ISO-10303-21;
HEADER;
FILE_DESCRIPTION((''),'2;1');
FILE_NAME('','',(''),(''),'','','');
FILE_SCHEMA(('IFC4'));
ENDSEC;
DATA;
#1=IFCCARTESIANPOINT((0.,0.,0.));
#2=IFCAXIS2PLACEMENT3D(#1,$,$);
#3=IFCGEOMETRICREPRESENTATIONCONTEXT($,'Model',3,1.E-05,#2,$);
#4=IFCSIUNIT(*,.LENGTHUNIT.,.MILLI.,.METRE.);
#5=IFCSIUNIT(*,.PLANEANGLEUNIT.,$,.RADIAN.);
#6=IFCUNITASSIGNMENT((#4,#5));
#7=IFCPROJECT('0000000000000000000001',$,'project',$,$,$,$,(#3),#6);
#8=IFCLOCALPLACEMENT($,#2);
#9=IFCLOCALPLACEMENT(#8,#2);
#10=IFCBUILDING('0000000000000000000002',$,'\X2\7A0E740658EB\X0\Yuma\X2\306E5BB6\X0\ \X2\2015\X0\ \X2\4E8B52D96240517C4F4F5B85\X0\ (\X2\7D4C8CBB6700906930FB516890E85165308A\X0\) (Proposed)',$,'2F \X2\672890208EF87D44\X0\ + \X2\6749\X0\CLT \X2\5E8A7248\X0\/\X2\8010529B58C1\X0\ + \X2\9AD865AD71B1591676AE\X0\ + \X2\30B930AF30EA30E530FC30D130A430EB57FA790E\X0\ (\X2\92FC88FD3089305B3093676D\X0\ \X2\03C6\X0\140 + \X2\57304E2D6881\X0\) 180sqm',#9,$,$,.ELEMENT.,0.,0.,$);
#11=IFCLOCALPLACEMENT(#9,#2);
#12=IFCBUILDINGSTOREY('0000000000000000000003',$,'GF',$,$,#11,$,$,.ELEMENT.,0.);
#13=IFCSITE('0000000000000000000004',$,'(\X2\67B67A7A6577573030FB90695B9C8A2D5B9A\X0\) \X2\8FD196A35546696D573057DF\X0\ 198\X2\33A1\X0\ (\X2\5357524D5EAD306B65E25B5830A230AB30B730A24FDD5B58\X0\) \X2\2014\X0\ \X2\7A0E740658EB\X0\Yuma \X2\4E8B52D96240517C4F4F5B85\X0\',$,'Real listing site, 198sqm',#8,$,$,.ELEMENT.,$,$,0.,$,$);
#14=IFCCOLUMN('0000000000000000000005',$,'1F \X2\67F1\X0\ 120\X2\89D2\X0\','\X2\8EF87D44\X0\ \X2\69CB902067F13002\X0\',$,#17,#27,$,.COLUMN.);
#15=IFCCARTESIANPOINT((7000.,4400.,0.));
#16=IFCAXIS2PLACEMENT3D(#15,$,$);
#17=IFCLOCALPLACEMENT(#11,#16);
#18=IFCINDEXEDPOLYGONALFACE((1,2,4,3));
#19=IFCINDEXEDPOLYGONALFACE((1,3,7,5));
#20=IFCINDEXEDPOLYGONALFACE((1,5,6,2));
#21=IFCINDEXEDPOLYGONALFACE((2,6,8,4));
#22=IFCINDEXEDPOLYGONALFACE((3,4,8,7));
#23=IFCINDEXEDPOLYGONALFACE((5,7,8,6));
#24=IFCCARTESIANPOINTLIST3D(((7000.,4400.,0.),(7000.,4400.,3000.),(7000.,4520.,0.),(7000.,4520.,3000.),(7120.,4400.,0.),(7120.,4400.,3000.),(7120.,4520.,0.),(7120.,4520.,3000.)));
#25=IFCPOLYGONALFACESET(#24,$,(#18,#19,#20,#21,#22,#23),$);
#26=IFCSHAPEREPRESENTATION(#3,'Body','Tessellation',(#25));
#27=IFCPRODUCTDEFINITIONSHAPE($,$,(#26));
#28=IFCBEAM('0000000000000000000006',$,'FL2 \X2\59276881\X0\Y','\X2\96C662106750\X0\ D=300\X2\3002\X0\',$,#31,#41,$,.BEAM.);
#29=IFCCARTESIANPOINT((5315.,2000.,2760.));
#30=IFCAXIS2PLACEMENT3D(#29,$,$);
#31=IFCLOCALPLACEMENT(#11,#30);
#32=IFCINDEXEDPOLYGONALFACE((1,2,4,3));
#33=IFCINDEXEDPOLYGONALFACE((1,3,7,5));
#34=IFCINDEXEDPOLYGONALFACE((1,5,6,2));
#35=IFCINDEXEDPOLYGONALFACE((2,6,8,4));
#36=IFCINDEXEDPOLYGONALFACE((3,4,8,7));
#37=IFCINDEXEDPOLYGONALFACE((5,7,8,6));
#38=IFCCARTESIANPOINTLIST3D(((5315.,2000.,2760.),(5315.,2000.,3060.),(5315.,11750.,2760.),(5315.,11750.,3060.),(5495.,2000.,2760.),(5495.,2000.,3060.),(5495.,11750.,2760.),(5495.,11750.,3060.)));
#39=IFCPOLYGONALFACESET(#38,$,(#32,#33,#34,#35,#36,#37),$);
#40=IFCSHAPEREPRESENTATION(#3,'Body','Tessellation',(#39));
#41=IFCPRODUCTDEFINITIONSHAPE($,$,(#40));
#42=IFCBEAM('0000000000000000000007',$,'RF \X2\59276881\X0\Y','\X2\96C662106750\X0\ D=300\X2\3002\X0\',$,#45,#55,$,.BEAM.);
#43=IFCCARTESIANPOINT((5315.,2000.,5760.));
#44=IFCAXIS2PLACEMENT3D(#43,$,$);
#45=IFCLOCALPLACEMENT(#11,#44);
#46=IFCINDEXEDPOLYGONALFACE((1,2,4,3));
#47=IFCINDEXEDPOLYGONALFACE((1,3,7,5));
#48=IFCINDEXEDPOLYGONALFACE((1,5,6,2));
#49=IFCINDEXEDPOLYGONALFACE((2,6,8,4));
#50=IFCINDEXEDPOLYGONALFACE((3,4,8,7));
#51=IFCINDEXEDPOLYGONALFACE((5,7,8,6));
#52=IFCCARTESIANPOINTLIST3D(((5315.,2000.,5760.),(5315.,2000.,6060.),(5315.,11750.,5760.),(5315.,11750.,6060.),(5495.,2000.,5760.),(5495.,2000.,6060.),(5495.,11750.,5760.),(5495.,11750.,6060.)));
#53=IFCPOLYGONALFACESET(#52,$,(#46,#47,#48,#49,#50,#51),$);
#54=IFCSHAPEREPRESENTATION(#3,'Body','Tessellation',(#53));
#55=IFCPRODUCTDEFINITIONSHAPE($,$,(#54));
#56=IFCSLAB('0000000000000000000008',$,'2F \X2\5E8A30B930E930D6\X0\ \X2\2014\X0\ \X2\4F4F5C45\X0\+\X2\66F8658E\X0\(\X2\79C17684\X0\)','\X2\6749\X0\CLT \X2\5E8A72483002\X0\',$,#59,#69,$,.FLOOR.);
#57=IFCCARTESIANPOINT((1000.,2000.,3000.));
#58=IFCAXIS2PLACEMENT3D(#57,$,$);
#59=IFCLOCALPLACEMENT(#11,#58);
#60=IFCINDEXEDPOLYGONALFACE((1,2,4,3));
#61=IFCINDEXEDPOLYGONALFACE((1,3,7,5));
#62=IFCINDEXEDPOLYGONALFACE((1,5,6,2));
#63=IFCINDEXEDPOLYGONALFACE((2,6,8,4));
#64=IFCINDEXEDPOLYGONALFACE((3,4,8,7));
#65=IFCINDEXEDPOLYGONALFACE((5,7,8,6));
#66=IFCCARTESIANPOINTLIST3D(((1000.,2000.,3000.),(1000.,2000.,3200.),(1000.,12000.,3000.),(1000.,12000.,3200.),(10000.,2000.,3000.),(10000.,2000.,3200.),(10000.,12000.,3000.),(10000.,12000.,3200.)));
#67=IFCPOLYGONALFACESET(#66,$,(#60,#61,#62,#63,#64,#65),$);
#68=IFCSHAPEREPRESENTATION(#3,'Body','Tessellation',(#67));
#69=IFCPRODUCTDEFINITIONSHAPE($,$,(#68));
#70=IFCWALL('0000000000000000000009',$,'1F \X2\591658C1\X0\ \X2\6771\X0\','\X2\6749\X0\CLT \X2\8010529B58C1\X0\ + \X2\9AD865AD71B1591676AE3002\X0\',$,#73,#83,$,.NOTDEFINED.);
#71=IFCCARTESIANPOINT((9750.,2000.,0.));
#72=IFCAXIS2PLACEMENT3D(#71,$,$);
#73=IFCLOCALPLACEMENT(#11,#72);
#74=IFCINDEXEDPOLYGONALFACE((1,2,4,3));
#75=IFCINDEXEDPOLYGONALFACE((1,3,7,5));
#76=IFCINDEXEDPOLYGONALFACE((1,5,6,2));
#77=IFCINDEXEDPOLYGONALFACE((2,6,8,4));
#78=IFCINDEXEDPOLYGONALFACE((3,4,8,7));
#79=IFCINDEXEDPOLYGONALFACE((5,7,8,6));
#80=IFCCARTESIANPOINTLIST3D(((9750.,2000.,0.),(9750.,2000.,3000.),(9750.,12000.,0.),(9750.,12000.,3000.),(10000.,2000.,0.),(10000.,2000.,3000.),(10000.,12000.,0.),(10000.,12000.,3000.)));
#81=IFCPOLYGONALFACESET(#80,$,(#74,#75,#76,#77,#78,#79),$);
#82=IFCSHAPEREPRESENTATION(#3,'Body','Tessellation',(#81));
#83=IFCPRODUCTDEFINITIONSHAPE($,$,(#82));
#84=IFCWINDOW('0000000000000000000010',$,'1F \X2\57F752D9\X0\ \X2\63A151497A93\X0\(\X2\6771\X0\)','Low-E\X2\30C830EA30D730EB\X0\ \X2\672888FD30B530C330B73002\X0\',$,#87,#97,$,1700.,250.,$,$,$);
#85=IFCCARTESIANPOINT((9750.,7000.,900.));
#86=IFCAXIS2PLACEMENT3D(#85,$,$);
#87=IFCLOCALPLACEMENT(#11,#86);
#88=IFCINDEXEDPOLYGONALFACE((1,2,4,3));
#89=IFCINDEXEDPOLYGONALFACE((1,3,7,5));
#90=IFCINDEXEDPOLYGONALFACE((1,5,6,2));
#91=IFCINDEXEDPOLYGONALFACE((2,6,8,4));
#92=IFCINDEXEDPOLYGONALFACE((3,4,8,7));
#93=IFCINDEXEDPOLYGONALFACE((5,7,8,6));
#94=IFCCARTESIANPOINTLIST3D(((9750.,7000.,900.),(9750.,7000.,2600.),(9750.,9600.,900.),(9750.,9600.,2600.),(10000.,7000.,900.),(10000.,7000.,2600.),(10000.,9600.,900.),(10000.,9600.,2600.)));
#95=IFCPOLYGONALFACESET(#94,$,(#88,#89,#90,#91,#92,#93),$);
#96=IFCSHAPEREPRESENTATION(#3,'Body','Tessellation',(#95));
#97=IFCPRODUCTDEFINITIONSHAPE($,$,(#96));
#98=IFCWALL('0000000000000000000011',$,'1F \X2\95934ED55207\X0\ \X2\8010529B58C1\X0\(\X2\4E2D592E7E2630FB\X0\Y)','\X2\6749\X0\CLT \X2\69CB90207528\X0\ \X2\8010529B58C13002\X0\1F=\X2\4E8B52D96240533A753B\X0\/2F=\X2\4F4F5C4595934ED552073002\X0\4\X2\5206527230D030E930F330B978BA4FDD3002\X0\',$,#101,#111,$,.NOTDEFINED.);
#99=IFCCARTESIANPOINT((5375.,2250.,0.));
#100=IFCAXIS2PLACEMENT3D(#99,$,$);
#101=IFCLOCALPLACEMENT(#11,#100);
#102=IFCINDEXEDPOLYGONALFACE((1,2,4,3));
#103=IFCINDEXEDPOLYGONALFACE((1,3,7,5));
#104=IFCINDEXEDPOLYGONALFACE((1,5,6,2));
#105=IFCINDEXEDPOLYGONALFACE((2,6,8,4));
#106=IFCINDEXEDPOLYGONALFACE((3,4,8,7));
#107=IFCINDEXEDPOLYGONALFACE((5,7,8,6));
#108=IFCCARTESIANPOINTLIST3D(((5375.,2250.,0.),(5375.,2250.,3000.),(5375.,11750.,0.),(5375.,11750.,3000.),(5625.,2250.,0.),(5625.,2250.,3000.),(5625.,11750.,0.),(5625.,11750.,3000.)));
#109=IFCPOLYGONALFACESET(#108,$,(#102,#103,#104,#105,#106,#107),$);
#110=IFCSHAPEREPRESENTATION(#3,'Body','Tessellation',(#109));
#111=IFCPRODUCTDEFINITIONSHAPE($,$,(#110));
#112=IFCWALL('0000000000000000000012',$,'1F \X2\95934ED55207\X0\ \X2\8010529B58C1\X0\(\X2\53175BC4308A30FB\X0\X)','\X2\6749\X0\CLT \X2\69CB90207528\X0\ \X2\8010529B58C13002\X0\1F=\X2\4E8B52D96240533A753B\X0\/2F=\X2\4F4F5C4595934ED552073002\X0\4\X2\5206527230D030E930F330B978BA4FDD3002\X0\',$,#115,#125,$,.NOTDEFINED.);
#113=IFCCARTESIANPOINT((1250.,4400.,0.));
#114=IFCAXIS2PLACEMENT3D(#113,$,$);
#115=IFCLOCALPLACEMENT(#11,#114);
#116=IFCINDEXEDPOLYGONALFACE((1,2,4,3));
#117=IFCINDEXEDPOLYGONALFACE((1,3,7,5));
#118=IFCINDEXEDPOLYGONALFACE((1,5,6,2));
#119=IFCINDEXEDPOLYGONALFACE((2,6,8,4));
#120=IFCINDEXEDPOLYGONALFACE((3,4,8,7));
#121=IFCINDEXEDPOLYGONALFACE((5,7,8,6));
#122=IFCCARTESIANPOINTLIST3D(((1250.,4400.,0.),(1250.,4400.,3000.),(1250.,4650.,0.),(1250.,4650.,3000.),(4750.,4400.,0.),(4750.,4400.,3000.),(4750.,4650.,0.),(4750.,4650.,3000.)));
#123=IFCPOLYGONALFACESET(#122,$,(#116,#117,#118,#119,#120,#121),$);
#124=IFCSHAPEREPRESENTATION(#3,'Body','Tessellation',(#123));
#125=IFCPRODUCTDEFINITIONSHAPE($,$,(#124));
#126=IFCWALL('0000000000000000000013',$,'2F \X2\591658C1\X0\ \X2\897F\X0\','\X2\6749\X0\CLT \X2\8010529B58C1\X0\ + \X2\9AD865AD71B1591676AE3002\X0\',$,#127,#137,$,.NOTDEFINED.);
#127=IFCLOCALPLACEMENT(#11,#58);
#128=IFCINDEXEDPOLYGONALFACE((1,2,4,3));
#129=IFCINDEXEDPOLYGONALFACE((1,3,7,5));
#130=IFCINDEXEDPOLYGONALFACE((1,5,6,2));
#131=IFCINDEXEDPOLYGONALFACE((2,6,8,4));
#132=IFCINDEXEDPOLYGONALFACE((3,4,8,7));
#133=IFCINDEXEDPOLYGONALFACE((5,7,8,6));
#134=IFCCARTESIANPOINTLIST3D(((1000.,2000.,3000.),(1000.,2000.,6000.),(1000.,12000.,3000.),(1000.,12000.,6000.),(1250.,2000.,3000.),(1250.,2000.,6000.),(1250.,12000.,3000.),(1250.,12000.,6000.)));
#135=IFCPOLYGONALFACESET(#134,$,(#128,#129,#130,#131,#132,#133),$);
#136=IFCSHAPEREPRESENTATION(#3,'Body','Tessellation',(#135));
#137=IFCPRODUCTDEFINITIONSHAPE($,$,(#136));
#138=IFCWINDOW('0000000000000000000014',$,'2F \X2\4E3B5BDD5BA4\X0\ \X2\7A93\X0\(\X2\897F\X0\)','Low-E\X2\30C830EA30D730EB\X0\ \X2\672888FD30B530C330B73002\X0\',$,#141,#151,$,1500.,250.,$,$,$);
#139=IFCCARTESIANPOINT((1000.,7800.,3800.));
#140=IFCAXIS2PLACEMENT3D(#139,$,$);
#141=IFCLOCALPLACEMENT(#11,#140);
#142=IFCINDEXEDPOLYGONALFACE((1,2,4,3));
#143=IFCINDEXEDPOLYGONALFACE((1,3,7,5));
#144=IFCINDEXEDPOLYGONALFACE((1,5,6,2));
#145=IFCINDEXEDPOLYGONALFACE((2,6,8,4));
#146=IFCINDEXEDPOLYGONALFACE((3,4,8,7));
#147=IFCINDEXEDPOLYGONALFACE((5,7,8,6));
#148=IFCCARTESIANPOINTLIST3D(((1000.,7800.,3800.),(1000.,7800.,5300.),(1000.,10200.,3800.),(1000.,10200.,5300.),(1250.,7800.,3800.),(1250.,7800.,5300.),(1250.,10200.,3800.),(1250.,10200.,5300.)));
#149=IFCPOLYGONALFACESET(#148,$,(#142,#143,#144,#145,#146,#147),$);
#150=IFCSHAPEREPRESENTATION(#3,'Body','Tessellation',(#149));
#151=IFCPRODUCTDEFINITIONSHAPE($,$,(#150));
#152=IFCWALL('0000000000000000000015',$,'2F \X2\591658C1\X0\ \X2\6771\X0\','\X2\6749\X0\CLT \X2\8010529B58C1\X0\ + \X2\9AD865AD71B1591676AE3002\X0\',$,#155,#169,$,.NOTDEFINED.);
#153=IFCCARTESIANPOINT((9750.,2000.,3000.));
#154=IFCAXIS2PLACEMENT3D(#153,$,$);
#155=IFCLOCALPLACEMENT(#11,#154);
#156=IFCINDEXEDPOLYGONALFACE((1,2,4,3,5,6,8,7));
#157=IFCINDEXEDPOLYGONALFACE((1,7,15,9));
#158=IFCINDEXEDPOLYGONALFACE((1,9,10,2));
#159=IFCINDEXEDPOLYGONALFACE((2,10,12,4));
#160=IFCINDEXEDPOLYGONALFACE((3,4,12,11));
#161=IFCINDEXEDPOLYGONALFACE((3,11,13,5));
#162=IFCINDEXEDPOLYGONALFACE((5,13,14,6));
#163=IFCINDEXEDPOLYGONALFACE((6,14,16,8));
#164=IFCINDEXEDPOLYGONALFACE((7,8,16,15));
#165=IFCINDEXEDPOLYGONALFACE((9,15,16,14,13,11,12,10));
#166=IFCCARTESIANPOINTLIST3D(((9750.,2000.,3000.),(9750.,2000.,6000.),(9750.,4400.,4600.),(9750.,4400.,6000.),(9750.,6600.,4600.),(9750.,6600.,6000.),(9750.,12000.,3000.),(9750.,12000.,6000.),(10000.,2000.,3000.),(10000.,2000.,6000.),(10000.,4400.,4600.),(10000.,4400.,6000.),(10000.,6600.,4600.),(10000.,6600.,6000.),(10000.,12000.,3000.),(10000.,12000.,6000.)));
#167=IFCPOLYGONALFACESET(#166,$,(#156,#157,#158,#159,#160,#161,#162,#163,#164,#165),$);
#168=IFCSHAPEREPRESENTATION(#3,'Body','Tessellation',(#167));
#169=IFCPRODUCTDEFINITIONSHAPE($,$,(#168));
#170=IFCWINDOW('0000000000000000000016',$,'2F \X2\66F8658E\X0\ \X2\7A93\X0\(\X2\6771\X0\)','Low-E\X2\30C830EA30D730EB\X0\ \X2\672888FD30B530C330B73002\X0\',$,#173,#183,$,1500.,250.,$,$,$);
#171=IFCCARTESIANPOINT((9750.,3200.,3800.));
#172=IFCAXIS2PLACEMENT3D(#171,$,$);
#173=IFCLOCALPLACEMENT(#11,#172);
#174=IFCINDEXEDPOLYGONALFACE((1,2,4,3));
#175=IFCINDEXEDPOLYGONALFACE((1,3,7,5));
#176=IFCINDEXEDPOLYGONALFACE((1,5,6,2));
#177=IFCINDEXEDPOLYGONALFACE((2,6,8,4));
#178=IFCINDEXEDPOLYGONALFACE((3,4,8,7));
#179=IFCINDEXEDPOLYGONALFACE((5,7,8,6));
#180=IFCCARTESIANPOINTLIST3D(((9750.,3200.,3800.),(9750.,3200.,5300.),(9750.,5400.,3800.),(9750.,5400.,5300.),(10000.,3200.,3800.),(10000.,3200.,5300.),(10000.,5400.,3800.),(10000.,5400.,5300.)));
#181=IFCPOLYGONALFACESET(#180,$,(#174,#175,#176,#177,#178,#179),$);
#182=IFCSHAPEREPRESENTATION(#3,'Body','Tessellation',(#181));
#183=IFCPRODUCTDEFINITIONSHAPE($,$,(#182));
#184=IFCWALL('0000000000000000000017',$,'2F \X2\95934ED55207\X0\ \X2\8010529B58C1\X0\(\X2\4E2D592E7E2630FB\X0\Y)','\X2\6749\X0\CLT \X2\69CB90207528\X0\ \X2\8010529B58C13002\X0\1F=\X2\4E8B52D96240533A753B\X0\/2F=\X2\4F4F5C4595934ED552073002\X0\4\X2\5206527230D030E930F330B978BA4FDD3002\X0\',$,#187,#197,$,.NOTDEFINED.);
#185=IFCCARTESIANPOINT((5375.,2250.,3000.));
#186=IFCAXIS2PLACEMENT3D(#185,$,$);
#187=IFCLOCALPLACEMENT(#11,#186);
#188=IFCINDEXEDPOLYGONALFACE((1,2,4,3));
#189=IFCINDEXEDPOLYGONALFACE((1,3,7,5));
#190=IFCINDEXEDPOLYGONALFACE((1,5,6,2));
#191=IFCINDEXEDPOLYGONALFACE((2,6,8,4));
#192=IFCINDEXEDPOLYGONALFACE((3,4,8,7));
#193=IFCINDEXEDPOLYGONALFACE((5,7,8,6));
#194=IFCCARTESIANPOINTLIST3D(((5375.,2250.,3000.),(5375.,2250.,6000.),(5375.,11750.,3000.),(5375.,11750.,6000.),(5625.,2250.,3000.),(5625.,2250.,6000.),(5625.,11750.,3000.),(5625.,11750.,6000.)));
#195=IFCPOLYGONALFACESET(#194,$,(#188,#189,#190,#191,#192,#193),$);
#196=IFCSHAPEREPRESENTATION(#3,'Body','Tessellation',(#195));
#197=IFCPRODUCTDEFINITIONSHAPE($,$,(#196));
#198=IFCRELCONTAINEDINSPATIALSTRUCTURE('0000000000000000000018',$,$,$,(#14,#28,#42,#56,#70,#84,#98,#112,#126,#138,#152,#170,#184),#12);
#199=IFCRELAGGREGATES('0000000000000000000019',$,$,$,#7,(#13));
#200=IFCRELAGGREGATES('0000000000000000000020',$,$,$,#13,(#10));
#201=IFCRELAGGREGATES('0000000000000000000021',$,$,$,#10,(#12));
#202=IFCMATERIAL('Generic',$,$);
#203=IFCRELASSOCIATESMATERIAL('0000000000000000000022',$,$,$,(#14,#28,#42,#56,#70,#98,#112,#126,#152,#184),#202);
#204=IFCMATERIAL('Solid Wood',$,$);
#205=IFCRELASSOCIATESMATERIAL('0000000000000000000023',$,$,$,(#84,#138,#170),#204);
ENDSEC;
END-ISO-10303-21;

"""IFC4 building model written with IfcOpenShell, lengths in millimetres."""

from ifc_helpers import new_model, si_unit, frame, frame_2d, origin, place, context, project, spatial, rectangle, extrude, material, element, fill, save


model = new_model("IFC4")

# Units and contexts
model_context = context("Model", 3, precision=1e-05, world=origin())
ifc_project = project(units=[si_unit("LENGTHUNIT", "METRE", prefix="MILLI"), si_unit("PLANEANGLEUNIT", "RADIAN")], contexts=[model_context])

# Site, building, storey
site_placement = place(None, origin())
site = spatial("IfcSite", under=ifc_project, at=site_placement, Name="(架空敷地・適宜設定) 近隣商業地域 198㎡ (南前庭に既存アカシア保存) — 税理士Yuma 事務所兼住宅", ObjectType="Real listing site, 198sqm", CompositionType="ELEMENT", RefElevation=0.0)
building_placement = place(site_placement, origin())
building = spatial("IfcBuilding", under=site, at=building_placement, Name="税理士Yumaの家 ― 事務所兼住宅 (経費最適・全部入り) (Proposed)", ObjectType="2F 木造軸組 + 杉CLT 床版/耐力壁 + 高断熱外皮 + スクリューパイル基礎 (鋼製らせん杭 φ140 + 地中梁) 180sqm", CompositionType="ELEMENT", ElevationOfRefHeight=0.0, ElevationOfTerrain=0.0)
storey_placement = place(building_placement, origin())
storey = spatial("IfcBuildingStorey", under=building, at=storey_placement, Name="GF", CompositionType="ELEMENT", Elevation=0.0)

# Column
ifc_material_1 = material(Name="Generic")
column_1_placement = place(storey_placement, frame((7000.0, 4400.0, 0.0)))
element("IfcColumn", 1, at=column_1_placement, inside=storey, material=ifc_material_1, Name="1F 柱 120角", Description="軸組 構造柱。", PredefinedType="COLUMN", context=model_context, shape_type="SweptSolid", body=[
    extrude(rectangle(XDim=120.0, YDim=120.0, at=frame_2d((60.0, 60.0))), frame((7000.0, 4400.0, 0.0)), (0.0, 0.0, 1.0), 3000.0),
])

# Beams
beam_1_placement = place(storey_placement, frame((5315.0, 2000.0, 2760.0)))
element("IfcBeam", 2, at=beam_1_placement, inside=storey, material=ifc_material_1, Name="FL2 大梁Y", Description="集成材 D=300。", PredefinedType="BEAM", context=model_context, shape_type="SweptSolid", body=[
    extrude(rectangle(XDim=180.0, YDim=9750.0, at=frame_2d((90.0, 4875.0))), frame((5315.0, 2000.0, 2760.0)), (0.0, 0.0, 1.0), 300.0),
])
beam_2_placement = place(storey_placement, frame((5315.0, 2000.0, 5760.0)))
element("IfcBeam", 3, at=beam_2_placement, inside=storey, material=ifc_material_1, Name="RF 大梁Y", Description="集成材 D=300。", PredefinedType="BEAM", context=model_context, shape_type="SweptSolid", body=[
    extrude(rectangle(XDim=180.0, YDim=9750.0, at=frame_2d((90.0, 4875.0))), frame((5315.0, 2000.0, 5760.0)), (0.0, 0.0, 1.0), 300.0),
])

# Slab
slab_1_placement = place(storey_placement, frame((1000.0, 2000.0, 3000.0)))
element("IfcSlab", 4, at=slab_1_placement, inside=storey, material=ifc_material_1, Name="2F 床スラブ — 住居+書斎(私的)", Description="杉CLT 床版。", PredefinedType="FLOOR", context=model_context, shape_type="SweptSolid", body=[
    extrude(rectangle(XDim=9000.0, YDim=10000.0, at=frame_2d((4500.0, 5000.0))), frame((1000.0, 2000.0, 3000.0)), (0.0, 0.0, 1.0), 200.0),
])

# Wall, opening, window
ifc_material_2 = material(Name="Solid Wood")
wall_1_placement = place(storey_placement, frame((9750.0, 2000.0, 0.0)))
wall_1 = element("IfcWall", 5, at=wall_1_placement, inside=storey, material=ifc_material_1, Name="1F 外壁 東", Description="杉CLT 耐力壁 + 高断熱外皮。", PredefinedType="NOTDEFINED", context=model_context, shape_type="SweptSolid", body=[
    extrude(rectangle(XDim=250.0, YDim=10000.0, at=frame_2d((125.0, 5000.0))), frame((9750.0, 2000.0, 0.0)), (0.0, 0.0, 1.0), 3000.0),
])
opening_1_placement = place(storey_placement, frame((9750.0, 7000.0, 900.0)))
opening_1 = element("IfcOpeningElement", 6, at=opening_1_placement, cuts=wall_1, PredefinedType="NOTDEFINED", context=model_context, shape_type="SweptSolid", body=[
    extrude(rectangle(XDim=250.0, YDim=2600.0, at=frame_2d((125.0, 1300.0))), frame((9750.0, 7000.0, 900.0)), (0.0, 0.0, 1.0), 1700.0),
])
window_1_placement = place(storey_placement, frame((9750.0, 7000.0, 900.0)))
window_1 = element("IfcWindow", 7, at=window_1_placement, inside=storey, material=ifc_material_2, Name="1F 執務 採光窓(東)", Description="Low-Eトリプル 木製サッシ。", OverallHeight=1700.0, OverallWidth=250.0, context=model_context, shape_type="SweptSolid", body=[
    extrude(rectangle(XDim=250.0, YDim=2600.0, at=frame_2d((125.0, 1300.0))), frame((9750.0, 7000.0, 900.0)), (0.0, 0.0, 1.0), 1700.0),
])
fill(opening_1, window_1)

# Walls
wall_2_placement = place(storey_placement, frame((5375.0, 2250.0, 0.0)))
element("IfcWall", 8, at=wall_2_placement, inside=storey, material=ifc_material_1, Name="1F 間仕切 耐力壁(中央縦・Y)", Description="杉CLT 構造用 耐力壁。1F=事務所区画/2F=住居間仕切。4分割バランス確保。", PredefinedType="NOTDEFINED", context=model_context, shape_type="SweptSolid", body=[
    extrude(rectangle(XDim=250.0, YDim=9500.0, at=frame_2d((125.0, 4750.0))), frame((5375.0, 2250.0, 0.0)), (0.0, 0.0, 1.0), 3000.0),
])
wall_3_placement = place(storey_placement, frame((1250.0, 4400.0, 0.0)))
element("IfcWall", 9, at=wall_3_placement, inside=storey, material=ifc_material_1, Name="1F 間仕切 耐力壁(北寄り・X)", Description="杉CLT 構造用 耐力壁。1F=事務所区画/2F=住居間仕切。4分割バランス確保。", PredefinedType="NOTDEFINED", context=model_context, shape_type="SweptSolid", body=[
    extrude(rectangle(XDim=3500.0, YDim=250.0, at=frame_2d((1750.0, 125.0))), frame((1250.0, 4400.0, 0.0)), (0.0, 0.0, 1.0), 3000.0),
])

# Walls, openings, windows
wall_4_placement = place(storey_placement, frame((1000.0, 2000.0, 3000.0)))
wall_4 = element("IfcWall", 10, at=wall_4_placement, inside=storey, material=ifc_material_1, Name="2F 外壁 西", Description="杉CLT 耐力壁 + 高断熱外皮。", PredefinedType="NOTDEFINED", context=model_context, shape_type="SweptSolid", body=[
    extrude(rectangle(XDim=250.0, YDim=10000.0, at=frame_2d((125.0, 5000.0))), frame((1000.0, 2000.0, 3000.0)), (0.0, 0.0, 1.0), 3000.0),
])
opening_2_placement = place(storey_placement, frame((1000.0, 7800.0, 3800.0)))
opening_2 = element("IfcOpeningElement", 11, at=opening_2_placement, cuts=wall_4, PredefinedType="NOTDEFINED", context=model_context, shape_type="SweptSolid", body=[
    extrude(rectangle(XDim=250.0, YDim=2400.0, at=frame_2d((125.0, 1200.0))), frame((1000.0, 7800.0, 3800.0)), (0.0, 0.0, 1.0), 1500.0),
])
window_2_placement = place(storey_placement, frame((1000.0, 7800.0, 3800.0)))
window_2 = element("IfcWindow", 12, at=window_2_placement, inside=storey, material=ifc_material_2, Name="2F 主寝室 窓(西)", Description="Low-Eトリプル 木製サッシ。", OverallHeight=1500.0, OverallWidth=250.0, context=model_context, shape_type="SweptSolid", body=[
    extrude(rectangle(XDim=250.0, YDim=2400.0, at=frame_2d((125.0, 1200.0))), frame((1000.0, 7800.0, 3800.0)), (0.0, 0.0, 1.0), 1500.0),
])
fill(opening_2, window_2)
wall_5_placement = place(storey_placement, frame((9750.0, 2000.0, 3000.0)))
wall_5 = element("IfcWall", 13, at=wall_5_placement, inside=storey, material=ifc_material_1, Name="2F 外壁 東", Description="杉CLT 耐力壁 + 高断熱外皮。", PredefinedType="NOTDEFINED", context=model_context, shape_type="SweptSolid", body=[
    extrude(rectangle(XDim=250.0, YDim=10000.0, at=frame_2d((125.0, 5000.0))), frame((9750.0, 2000.0, 3000.0)), (0.0, 0.0, 1.0), 3000.0),
])
opening_3_placement = place(storey_placement, frame((9750.0, 3200.0, 3800.0)))
opening_3 = element("IfcOpeningElement", 14, at=opening_3_placement, cuts=wall_5, PredefinedType="NOTDEFINED", context=model_context, shape_type="SweptSolid", body=[
    extrude(rectangle(XDim=250.0, YDim=2200.0, at=frame_2d((125.0, 1100.0))), frame((9750.0, 3200.0, 3800.0)), (0.0, 0.0, 1.0), 1500.0),
])
window_3_placement = place(storey_placement, frame((9750.0, 3200.0, 3800.0)))
window_3 = element("IfcWindow", 15, at=window_3_placement, inside=storey, material=ifc_material_2, Name="2F 書斎 窓(東)", Description="Low-Eトリプル 木製サッシ。", OverallHeight=1500.0, OverallWidth=250.0, context=model_context, shape_type="SweptSolid", body=[
    extrude(rectangle(XDim=250.0, YDim=2200.0, at=frame_2d((125.0, 1100.0))), frame((9750.0, 3200.0, 3800.0)), (0.0, 0.0, 1.0), 1500.0),
])
fill(opening_3, window_3)

# Wall
wall_6_placement = place(storey_placement, frame((5375.0, 2250.0, 3000.0)))
element("IfcWall", 16, at=wall_6_placement, inside=storey, material=ifc_material_1, Name="2F 間仕切 耐力壁(中央縦・Y)", Description="杉CLT 構造用 耐力壁。1F=事務所区画/2F=住居間仕切。4分割バランス確保。", PredefinedType="NOTDEFINED", context=model_context, shape_type="SweptSolid", body=[
    extrude(rectangle(XDim=250.0, YDim=9500.0, at=frame_2d((125.0, 4750.0))), frame((5375.0, 2250.0, 3000.0)), (0.0, 0.0, 1.0), 3000.0),
])

save(model, "model.ifc")
